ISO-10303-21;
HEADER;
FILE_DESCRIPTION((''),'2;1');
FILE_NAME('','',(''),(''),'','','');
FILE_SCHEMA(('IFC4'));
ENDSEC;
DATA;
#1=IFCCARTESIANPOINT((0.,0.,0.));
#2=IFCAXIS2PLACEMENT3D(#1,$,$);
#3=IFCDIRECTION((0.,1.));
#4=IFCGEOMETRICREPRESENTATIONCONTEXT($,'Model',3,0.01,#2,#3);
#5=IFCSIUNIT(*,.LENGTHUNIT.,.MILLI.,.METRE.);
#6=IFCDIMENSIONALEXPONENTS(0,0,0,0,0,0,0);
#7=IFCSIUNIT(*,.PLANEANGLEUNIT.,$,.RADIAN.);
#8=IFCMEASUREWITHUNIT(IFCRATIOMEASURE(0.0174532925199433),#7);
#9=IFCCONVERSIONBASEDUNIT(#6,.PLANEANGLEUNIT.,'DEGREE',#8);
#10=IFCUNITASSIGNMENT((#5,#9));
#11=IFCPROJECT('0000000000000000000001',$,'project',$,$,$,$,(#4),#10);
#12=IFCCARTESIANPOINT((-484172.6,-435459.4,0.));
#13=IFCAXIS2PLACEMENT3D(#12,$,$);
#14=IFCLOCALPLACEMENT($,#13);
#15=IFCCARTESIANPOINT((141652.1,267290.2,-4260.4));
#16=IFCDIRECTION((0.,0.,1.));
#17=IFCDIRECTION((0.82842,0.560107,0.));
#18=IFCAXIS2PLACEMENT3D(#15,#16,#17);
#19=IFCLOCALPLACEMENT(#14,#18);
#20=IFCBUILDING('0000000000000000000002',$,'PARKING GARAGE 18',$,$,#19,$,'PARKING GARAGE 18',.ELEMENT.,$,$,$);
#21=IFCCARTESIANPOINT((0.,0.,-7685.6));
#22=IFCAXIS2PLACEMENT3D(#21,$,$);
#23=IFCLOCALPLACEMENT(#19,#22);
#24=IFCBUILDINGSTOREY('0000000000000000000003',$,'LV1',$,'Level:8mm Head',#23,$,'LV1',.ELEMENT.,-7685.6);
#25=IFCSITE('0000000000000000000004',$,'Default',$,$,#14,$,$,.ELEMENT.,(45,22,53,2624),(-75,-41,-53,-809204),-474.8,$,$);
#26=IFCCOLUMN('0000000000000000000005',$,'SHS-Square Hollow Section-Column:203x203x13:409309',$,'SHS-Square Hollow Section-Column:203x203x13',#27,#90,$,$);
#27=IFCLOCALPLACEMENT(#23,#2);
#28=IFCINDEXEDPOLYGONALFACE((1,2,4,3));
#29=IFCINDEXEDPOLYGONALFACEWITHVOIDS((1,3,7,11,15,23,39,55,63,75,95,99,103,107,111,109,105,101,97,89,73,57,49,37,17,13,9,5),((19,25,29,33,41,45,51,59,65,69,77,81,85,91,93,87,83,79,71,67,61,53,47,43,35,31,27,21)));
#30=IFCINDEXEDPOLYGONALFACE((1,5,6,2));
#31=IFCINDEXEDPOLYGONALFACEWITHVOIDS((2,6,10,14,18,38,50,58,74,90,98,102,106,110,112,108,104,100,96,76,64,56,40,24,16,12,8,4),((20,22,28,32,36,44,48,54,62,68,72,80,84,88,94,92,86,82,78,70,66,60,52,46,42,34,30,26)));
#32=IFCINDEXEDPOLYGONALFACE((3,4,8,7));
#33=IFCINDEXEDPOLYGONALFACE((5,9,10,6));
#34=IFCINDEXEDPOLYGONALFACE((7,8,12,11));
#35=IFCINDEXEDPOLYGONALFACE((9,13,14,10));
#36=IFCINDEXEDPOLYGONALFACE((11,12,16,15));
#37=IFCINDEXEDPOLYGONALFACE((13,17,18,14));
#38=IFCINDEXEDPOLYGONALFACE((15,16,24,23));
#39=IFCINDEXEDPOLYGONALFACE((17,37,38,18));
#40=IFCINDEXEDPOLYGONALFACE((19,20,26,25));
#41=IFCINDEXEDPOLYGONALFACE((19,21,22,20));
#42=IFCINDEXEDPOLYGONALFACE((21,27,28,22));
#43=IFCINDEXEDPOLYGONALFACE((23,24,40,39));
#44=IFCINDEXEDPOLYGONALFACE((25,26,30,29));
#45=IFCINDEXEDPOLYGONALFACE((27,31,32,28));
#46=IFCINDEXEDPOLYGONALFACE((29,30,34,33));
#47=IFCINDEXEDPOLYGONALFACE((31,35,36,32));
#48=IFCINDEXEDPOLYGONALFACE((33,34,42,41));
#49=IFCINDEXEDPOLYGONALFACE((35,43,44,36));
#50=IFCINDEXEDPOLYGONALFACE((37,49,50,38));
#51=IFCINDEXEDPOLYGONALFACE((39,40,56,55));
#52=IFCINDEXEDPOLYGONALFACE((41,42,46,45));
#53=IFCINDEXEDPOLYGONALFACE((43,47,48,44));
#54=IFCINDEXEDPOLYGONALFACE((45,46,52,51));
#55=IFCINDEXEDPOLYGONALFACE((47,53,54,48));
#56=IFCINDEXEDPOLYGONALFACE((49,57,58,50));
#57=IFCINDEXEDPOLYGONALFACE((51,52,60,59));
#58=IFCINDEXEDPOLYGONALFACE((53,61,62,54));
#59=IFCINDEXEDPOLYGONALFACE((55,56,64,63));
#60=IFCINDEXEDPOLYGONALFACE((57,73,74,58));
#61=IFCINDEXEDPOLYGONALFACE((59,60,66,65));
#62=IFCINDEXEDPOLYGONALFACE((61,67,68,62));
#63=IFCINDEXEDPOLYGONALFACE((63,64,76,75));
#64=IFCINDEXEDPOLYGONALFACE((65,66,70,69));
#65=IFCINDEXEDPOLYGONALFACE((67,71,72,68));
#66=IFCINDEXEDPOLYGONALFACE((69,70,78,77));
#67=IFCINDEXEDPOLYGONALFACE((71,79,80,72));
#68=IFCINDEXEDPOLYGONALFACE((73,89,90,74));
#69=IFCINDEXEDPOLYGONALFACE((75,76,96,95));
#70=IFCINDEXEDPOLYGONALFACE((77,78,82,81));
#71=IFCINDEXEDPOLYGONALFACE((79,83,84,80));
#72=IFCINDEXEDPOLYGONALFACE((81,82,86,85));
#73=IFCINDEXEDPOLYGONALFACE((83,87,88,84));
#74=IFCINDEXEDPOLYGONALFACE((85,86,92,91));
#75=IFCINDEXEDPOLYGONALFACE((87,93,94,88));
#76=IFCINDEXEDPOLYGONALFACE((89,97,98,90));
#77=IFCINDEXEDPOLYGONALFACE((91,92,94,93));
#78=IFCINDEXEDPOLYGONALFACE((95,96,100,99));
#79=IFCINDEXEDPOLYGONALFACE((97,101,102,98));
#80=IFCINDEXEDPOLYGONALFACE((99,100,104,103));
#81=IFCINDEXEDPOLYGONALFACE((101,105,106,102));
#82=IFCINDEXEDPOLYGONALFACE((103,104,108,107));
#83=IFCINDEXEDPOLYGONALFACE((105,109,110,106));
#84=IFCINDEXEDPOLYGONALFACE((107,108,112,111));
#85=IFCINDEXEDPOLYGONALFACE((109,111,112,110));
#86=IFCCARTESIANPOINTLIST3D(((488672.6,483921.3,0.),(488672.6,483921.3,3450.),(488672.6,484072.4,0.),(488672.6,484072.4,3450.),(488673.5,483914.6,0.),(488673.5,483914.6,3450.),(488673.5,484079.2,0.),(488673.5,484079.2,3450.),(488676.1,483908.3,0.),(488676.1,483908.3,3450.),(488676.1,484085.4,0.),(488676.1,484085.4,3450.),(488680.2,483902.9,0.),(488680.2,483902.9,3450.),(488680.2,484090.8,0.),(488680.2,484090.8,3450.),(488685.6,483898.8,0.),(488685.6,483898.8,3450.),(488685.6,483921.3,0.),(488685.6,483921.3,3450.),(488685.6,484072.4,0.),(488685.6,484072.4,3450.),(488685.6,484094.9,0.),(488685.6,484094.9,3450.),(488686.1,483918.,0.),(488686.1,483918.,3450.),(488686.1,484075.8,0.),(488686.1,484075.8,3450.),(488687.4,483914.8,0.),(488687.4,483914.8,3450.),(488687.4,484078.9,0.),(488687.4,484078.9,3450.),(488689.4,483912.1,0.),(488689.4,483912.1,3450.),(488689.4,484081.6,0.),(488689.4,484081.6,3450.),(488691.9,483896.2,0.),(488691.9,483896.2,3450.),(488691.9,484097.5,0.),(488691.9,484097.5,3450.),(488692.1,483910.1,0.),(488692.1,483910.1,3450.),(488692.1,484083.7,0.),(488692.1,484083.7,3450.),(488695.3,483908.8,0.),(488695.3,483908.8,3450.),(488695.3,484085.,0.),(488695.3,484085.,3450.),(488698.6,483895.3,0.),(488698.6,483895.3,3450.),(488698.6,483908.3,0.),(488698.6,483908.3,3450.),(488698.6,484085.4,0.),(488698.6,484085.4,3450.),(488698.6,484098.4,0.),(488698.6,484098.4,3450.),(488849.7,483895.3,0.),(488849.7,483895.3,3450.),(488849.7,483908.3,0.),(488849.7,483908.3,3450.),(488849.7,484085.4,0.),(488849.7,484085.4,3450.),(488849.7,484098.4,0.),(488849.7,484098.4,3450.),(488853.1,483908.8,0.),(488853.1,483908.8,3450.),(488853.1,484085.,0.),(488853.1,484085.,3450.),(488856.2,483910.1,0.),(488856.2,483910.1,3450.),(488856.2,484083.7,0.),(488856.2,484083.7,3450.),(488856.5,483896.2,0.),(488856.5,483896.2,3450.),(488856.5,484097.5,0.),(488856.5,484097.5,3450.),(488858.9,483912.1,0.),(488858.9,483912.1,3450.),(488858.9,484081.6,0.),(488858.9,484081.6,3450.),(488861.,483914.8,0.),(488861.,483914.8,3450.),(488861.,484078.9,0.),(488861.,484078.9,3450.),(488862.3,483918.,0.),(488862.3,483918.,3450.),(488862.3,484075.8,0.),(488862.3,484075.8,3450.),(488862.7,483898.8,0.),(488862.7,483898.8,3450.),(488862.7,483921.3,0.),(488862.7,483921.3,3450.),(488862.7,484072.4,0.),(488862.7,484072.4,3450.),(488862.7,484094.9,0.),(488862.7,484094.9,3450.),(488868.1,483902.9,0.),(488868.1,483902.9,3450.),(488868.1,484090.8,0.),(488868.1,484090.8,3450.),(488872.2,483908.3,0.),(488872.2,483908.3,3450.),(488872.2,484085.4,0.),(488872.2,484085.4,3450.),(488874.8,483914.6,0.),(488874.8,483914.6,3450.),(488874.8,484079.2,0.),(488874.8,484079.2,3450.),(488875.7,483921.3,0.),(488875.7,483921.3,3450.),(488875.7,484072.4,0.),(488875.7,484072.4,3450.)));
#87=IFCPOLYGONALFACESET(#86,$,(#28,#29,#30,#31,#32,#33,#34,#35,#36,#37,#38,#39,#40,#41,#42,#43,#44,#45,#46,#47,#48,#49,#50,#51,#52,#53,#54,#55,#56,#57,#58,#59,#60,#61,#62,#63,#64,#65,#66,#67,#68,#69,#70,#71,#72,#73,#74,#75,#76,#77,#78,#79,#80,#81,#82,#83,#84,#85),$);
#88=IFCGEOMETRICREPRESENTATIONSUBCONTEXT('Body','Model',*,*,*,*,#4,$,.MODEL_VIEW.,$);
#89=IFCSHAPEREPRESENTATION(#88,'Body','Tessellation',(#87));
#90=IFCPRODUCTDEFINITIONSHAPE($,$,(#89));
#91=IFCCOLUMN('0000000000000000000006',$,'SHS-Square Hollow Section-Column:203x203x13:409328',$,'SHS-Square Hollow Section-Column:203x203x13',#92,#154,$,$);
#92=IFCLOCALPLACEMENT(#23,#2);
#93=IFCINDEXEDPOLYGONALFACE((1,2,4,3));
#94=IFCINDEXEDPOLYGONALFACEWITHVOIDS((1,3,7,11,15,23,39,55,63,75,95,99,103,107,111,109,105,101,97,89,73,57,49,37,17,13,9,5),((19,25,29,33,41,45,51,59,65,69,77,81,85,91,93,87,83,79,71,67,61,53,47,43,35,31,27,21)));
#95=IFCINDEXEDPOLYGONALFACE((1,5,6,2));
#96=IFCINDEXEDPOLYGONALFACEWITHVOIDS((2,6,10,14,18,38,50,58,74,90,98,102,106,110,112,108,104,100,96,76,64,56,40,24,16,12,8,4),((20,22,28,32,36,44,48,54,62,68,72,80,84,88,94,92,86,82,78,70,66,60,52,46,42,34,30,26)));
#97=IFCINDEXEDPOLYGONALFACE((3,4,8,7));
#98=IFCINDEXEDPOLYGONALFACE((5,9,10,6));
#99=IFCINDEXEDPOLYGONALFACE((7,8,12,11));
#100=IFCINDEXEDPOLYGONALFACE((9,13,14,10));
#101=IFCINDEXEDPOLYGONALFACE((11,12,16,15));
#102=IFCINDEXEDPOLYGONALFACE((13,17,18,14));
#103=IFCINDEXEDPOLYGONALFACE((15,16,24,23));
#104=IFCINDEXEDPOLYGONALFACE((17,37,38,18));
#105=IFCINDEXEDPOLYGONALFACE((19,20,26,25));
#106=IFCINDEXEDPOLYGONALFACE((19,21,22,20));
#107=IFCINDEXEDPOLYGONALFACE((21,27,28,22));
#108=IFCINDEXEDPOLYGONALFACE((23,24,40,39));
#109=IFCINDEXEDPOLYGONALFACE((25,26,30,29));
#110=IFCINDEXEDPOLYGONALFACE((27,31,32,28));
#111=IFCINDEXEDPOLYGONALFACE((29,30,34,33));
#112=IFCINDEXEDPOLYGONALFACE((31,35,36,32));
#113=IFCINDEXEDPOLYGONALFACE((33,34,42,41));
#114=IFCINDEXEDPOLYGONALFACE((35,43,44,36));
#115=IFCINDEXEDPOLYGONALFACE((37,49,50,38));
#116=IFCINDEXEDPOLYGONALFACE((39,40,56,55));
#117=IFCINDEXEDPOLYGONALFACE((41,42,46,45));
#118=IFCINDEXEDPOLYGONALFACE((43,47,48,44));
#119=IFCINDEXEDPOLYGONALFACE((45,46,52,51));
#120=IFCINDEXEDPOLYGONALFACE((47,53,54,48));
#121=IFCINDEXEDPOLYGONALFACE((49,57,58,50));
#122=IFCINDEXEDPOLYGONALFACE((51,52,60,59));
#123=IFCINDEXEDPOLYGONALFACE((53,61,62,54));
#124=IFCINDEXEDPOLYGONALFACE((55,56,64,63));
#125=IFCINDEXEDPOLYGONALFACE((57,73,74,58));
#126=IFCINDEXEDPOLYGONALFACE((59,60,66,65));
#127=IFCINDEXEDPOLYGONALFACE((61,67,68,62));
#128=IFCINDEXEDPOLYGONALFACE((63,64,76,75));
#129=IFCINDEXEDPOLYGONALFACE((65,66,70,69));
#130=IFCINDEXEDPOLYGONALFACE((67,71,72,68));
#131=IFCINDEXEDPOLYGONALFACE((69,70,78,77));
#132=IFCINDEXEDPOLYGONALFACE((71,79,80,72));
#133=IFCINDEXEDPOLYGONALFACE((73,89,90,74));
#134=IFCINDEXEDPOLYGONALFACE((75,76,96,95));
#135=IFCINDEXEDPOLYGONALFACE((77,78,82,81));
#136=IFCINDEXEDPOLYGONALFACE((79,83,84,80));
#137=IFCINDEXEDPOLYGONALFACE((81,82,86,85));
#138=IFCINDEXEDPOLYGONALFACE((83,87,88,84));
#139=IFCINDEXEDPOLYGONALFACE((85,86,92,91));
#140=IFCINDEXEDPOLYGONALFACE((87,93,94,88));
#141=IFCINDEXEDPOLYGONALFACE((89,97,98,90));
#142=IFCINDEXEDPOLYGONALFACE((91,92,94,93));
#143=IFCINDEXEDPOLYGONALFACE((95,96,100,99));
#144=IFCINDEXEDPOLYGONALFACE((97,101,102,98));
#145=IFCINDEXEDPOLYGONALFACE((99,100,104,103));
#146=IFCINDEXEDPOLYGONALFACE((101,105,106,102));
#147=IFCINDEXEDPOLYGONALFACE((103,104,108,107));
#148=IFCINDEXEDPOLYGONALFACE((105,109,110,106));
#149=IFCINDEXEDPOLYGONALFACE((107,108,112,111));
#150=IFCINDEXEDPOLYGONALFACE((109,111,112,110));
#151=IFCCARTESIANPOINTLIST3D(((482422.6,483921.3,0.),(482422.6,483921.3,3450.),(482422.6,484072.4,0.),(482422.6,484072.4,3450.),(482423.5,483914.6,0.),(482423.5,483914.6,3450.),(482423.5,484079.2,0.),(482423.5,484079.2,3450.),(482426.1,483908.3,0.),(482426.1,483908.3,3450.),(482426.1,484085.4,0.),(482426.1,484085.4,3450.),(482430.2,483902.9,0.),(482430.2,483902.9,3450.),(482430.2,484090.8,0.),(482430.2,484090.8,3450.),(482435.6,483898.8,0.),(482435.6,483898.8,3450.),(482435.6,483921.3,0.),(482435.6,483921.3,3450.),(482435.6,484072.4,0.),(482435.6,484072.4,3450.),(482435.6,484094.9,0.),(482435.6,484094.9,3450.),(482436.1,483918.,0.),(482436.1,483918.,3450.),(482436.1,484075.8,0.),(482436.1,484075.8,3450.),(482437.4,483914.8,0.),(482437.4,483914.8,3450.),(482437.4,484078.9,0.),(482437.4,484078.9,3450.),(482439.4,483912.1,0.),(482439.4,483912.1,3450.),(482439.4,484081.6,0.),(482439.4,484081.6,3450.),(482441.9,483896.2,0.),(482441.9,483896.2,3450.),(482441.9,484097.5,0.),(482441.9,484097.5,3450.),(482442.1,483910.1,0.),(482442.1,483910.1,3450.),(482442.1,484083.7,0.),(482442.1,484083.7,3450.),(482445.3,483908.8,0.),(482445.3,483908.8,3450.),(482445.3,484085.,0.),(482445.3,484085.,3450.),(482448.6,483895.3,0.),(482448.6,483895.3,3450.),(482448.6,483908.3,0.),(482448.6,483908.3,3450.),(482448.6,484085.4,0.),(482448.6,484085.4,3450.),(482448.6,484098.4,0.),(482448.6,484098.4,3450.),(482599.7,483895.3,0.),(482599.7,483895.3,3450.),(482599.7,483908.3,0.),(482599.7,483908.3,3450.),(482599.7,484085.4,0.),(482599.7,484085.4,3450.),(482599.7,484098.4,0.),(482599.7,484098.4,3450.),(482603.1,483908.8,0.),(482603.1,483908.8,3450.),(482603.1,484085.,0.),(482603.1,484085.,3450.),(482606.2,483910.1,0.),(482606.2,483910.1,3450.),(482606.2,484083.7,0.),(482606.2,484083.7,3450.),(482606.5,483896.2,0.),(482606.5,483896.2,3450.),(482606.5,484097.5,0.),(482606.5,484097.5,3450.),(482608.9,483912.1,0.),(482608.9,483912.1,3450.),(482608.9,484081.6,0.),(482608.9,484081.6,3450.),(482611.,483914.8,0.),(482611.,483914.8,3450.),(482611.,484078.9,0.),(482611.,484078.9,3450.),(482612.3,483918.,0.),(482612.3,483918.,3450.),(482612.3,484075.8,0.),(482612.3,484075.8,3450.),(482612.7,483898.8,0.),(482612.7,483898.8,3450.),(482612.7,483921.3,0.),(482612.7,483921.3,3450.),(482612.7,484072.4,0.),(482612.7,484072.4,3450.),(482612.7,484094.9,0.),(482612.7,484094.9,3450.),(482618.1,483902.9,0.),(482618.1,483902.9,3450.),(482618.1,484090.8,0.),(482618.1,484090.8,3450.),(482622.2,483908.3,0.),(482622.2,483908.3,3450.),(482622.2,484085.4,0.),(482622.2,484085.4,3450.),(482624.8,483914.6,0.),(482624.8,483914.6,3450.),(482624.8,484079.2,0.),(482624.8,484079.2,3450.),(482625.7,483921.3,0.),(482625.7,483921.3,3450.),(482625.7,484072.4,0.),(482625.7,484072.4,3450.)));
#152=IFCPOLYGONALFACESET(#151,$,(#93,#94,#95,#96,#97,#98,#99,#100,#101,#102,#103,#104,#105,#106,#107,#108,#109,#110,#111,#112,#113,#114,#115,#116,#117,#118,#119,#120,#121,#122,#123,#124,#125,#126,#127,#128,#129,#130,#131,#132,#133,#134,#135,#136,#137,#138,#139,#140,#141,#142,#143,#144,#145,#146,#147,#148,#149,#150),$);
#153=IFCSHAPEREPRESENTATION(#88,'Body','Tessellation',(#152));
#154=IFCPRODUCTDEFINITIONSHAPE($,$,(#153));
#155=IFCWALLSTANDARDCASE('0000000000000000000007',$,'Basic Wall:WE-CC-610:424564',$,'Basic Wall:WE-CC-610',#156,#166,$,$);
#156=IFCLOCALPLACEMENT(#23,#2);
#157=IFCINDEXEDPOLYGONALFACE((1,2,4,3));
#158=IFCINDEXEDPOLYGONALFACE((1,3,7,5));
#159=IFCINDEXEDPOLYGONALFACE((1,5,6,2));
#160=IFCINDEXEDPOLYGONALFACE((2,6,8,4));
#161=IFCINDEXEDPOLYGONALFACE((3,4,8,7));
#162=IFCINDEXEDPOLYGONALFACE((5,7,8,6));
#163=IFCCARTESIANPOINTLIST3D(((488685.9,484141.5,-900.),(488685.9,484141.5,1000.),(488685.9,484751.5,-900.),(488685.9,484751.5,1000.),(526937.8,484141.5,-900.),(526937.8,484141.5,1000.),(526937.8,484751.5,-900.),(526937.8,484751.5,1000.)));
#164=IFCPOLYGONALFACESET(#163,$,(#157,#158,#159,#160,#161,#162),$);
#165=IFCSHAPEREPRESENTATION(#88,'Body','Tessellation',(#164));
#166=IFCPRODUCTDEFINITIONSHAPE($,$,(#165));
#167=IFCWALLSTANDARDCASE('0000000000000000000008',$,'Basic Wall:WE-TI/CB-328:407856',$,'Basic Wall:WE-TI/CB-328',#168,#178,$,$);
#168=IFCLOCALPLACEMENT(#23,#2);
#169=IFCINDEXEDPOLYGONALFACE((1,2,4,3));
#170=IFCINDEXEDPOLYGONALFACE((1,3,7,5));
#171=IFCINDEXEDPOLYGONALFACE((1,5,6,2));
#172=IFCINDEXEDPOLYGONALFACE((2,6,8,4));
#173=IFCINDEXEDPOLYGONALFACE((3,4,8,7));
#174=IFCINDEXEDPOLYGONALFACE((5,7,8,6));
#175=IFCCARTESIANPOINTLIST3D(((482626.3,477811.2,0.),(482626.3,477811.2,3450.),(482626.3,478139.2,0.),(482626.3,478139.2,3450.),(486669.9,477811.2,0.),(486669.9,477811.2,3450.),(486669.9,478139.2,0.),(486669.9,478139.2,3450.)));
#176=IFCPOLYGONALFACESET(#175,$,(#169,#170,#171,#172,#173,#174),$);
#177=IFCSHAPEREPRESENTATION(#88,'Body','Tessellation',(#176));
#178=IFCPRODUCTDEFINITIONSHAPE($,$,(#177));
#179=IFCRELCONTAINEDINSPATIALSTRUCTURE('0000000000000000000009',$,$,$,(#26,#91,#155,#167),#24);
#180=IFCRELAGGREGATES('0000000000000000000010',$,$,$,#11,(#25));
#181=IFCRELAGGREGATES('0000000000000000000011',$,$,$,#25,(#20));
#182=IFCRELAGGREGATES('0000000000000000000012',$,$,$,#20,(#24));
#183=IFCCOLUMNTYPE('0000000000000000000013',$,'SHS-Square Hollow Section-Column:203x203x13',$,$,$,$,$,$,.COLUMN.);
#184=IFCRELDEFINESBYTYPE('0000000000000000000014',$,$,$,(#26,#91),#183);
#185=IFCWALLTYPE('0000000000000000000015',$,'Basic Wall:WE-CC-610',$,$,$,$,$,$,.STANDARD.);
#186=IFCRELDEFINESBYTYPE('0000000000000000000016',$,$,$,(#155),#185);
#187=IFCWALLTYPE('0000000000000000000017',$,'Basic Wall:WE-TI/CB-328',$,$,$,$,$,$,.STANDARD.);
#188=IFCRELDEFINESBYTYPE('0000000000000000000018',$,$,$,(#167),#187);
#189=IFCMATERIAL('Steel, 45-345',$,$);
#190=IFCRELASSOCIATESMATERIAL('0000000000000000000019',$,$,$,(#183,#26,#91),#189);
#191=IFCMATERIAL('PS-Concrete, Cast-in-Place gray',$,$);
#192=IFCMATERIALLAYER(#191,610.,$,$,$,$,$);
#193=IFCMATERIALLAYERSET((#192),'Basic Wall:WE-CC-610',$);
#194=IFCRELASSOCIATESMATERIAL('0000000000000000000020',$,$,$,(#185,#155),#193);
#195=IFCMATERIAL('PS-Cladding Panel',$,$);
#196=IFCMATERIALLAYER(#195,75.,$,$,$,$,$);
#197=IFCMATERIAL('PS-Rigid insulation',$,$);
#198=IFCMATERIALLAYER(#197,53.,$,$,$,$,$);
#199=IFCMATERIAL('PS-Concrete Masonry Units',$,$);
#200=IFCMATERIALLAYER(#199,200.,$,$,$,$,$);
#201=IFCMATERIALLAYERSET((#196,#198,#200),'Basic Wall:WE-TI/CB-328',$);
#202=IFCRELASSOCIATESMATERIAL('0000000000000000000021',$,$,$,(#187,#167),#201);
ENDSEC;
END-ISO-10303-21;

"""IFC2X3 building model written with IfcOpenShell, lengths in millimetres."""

from ifc_helpers import new_model, entity, si_unit, converted_unit, direction, frame, frame_2d, origin, place, context, subcontext, project, spatial, polyline, circle_curve, parameter, trimmed, segment, composite_curve, rectangle, outline, extrude, source, transform, mapped, material, layer, layer_set, layer_usage, type_object, type_shapes, element, save


model = new_model("IFC2X3")

# Units and contexts
model_context = context("Model", 3, precision=0.01, world=origin(), true_north=direction((0.0, 1.0)))
body_context = subcontext(model_context, "Body", "Model", "MODEL_VIEW")
ifc_project = project(units=[si_unit("LENGTHUNIT", "METRE", prefix="MILLI"), converted_unit("PLANEANGLEUNIT", "DEGREE", entity("IfcRatioMeasure", 0.0174532925199433), si_unit("PLANEANGLEUNIT", "RADIAN"), dimensions=[0, 0, 0, 0, 0, 0, 0])], contexts=[model_context])

# Site, building, storey
site_placement = place(None, frame((-484172.6, -435459.4, 0.0)))
site = spatial("IfcSite", under=ifc_project, at=site_placement, Name="Default", CompositionType="ELEMENT", RefLatitude=(45, 22, 53, 2624), RefLongitude=(-75, -41, -53, -809204), RefElevation=-474.8)
building_placement = place(site_placement, frame((141652.1, 267290.2, -4260.4), z_axis=(0.0, 0.0, 1.0), x_axis=(0.82842, 0.560107, 0.0)))
building = spatial("IfcBuilding", under=site, at=building_placement, Name="PARKING GARAGE 18", LongName="PARKING GARAGE 18", CompositionType="ELEMENT")
storey_placement = place(building_placement, frame((0.0, 0.0, -7685.6)))
storey = spatial("IfcBuildingStorey", under=building, at=storey_placement, Name="LV1", ObjectType="Level:8mm Head", LongName="LV1", CompositionType="ELEMENT", Elevation=-7685.6)

# Columns
ifc_material_1 = material(Name="Steel, 45-345")
column_type = type_object("IfcColumnType", Name="SHS-Square Hollow Section-Column:203x203x13", PredefinedType="COLUMN", material=ifc_material_1)
shared_shape_1 = source(origin(), body_context, "Body", "SweptSolid", [
    extrude(outline(composite_curve([segment(polyline([(-75.6, -101.5), (75.6, -101.5)]), True, "CONTINUOUS"), segment(trimmed(circle_curve(frame_2d((75.6, -75.6), x_axis=(-1.0, 0.0)), 26.0), [parameter(90.0)], [parameter(180.0)], True, "PARAMETER"), True, "CONTINUOUS"), segment(polyline([(101.5, -75.6), (101.5, 75.6)]), True, "CONTINUOUS"), segment(trimmed(circle_curve(frame_2d((75.5, 75.6), x_axis=(-1.0, 0.0)), 26.0), [parameter(180.0)], [parameter(270.0)], True, "PARAMETER"), True, "CONTINUOUS"), segment(polyline([(75.5, 101.6), (-75.5, 101.6)]), True, "CONTINUOUS"), segment(trimmed(circle_curve(frame_2d((-75.5, 75.5), x_axis=(-1.0, 0.0)), 26.0), [parameter(270.0)], [parameter(360.0)], True, "PARAMETER"), True, "CONTINUOUS"), segment(polyline([(-101.5, 75.5), (-101.5, -75.6)]), True, "CONTINUOUS"), segment(trimmed(circle_curve(frame_2d((-75.6, -75.6), x_axis=(-1.0, 0.0)), 26.0), [parameter(360.0)], [parameter(90.0)], True, "PARAMETER"), True, "CONTINUOUS")], self_intersect=False), holes=[composite_curve([segment(trimmed(circle_curve(frame_2d((-75.6, -75.6), x_axis=(-1.0, 0.0)), 13.0), [parameter(0.0)], [parameter(90.0)], True, "PARAMETER"), False, "CONTINUOUS"), segment(polyline([(-88.5, -75.6), (-88.5, 75.6)]), True, "CONTINUOUS"), segment(trimmed(circle_curve(frame_2d((-75.6, 75.6), x_axis=(-1.0, 0.0)), 13.0), [parameter(270.0)], [parameter(0.0)], True, "PARAMETER"), False, "CONTINUOUS"), segment(polyline([(-75.6, 88.6), (75.5, 88.6)]), True, "CONTINUOUS"), segment(trimmed(circle_curve(frame_2d((75.5, 75.5), x_axis=(-1.0, 0.0)), 13.0), [parameter(180.0)], [parameter(270.0)], True, "PARAMETER"), False, "CONTINUOUS"), segment(polyline([(88.6, 75.5), (88.6, -75.5)]), True, "CONTINUOUS"), segment(trimmed(circle_curve(frame_2d((75.6, -75.5), x_axis=(-1.0, 0.0)), 13.0), [parameter(90.0)], [parameter(180.0)], True, "PARAMETER"), False, "CONTINUOUS"), segment(polyline([(75.6, -88.5), (-75.6, -88.5)]), True, "CONTINUOUS")], self_intersect=False)]), frame((0.0, 0.0, -7685.6), z_axis=(0.0, 0.0, 1.0), x_axis=(-1.0, 0.0, 0.0)), (0.0, 0.0, 1.0), 3450.0),
])
type_shapes(column_type, [shared_shape_1])
for number, where, name in (
    (1, (488774.2, 483996.9, 7685.6), "SHS-Square Hollow Section-Column:203x203x13:409309"),
    (2, (482524.2, 483996.9, 7685.6), "SHS-Square Hollow Section-Column:203x203x13:409328"),
):
    element("IfcColumn", number, at=place(storey_placement, frame(where)), inside=storey, type_object=column_type, material=ifc_material_1, Name=name, ObjectType="SHS-Square Hollow Section-Column:203x203x13", context=body_context, shape_type="MappedRepresentation", body=[
        mapped(shared_shape_1, transform((0.0, 0.0, 0.0), scale=1.0)),
    ])

# Wall
ifc_material_2 = material(Name="PS-Concrete, Cast-in-Place gray")
ifc_layer_1 = layer(ifc_material_2, 610.0)
ifc_layer_set_1 = layer_set([ifc_layer_1], Name="Basic Wall:WE-CC-610")
ifc_layer_usage_1 = layer_usage(ifc_layer_set_1, "AXIS2", "POSITIVE", -305.0)
wall_type_1 = type_object("IfcWallType", Name="Basic Wall:WE-CC-610", PredefinedType="STANDARD", material=ifc_layer_set_1)
wall_1_placement = place(storey_placement, frame((488685.9, 484446.5, -900.0)))
element("IfcWallStandardCase", 3, at=wall_1_placement, inside=storey, type_object=wall_type_1, material=ifc_layer_usage_1, Name="Basic Wall:WE-CC-610:424564", ObjectType="Basic Wall:WE-CC-610", context=body_context, shape_type="SweptSolid", body=[
    extrude(rectangle(XDim=38251.9, YDim=610.0, at=frame_2d((19125.9, 0.0), x_axis=(-1.0, 0.0))), origin(), (0.0, 0.0, 1.0), 1900.0),
])

# Shared definitions
ifc_material_3 = material(Name="PS-Cladding Panel")
ifc_layer_2 = layer(ifc_material_3, 75.0)
ifc_material_4 = material(Name="PS-Rigid insulation")
ifc_layer_3 = layer(ifc_material_4, 53.0)
ifc_material_5 = material(Name="PS-Concrete Masonry Units")
ifc_layer_4 = layer(ifc_material_5, 200.0)
ifc_layer_set_2 = layer_set([ifc_layer_2, ifc_layer_3, ifc_layer_4], Name="Basic Wall:WE-TI/CB-328")
wall_type_2 = type_object("IfcWallType", Name="Basic Wall:WE-TI/CB-328", PredefinedType="STANDARD", material=ifc_layer_set_2)

# Wall
ifc_layer_usage_2 = layer_usage(ifc_layer_set_2, "AXIS2", "NEGATIVE", 164.0)
wall_2_placement = place(storey_placement, frame((486669.9, 477975.2, 0.0), z_axis=(0.0, 0.0, 1.0), x_axis=(-1.0, 0.0, 0.0)))
element("IfcWallStandardCase", 4, at=wall_2_placement, inside=storey, type_object=wall_type_2, material=ifc_layer_usage_2, Name="Basic Wall:WE-TI/CB-328:407856", ObjectType="Basic Wall:WE-TI/CB-328", context=body_context, shape_type="SweptSolid", body=[
    extrude(rectangle(XDim=4043.6, YDim=328.0, at=frame_2d((2021.8, 0.0), x_axis=(-1.0, 0.0))), origin(), (0.0, 0.0, 1.0), 3450.0),
])

save(model, "model.ifc")
